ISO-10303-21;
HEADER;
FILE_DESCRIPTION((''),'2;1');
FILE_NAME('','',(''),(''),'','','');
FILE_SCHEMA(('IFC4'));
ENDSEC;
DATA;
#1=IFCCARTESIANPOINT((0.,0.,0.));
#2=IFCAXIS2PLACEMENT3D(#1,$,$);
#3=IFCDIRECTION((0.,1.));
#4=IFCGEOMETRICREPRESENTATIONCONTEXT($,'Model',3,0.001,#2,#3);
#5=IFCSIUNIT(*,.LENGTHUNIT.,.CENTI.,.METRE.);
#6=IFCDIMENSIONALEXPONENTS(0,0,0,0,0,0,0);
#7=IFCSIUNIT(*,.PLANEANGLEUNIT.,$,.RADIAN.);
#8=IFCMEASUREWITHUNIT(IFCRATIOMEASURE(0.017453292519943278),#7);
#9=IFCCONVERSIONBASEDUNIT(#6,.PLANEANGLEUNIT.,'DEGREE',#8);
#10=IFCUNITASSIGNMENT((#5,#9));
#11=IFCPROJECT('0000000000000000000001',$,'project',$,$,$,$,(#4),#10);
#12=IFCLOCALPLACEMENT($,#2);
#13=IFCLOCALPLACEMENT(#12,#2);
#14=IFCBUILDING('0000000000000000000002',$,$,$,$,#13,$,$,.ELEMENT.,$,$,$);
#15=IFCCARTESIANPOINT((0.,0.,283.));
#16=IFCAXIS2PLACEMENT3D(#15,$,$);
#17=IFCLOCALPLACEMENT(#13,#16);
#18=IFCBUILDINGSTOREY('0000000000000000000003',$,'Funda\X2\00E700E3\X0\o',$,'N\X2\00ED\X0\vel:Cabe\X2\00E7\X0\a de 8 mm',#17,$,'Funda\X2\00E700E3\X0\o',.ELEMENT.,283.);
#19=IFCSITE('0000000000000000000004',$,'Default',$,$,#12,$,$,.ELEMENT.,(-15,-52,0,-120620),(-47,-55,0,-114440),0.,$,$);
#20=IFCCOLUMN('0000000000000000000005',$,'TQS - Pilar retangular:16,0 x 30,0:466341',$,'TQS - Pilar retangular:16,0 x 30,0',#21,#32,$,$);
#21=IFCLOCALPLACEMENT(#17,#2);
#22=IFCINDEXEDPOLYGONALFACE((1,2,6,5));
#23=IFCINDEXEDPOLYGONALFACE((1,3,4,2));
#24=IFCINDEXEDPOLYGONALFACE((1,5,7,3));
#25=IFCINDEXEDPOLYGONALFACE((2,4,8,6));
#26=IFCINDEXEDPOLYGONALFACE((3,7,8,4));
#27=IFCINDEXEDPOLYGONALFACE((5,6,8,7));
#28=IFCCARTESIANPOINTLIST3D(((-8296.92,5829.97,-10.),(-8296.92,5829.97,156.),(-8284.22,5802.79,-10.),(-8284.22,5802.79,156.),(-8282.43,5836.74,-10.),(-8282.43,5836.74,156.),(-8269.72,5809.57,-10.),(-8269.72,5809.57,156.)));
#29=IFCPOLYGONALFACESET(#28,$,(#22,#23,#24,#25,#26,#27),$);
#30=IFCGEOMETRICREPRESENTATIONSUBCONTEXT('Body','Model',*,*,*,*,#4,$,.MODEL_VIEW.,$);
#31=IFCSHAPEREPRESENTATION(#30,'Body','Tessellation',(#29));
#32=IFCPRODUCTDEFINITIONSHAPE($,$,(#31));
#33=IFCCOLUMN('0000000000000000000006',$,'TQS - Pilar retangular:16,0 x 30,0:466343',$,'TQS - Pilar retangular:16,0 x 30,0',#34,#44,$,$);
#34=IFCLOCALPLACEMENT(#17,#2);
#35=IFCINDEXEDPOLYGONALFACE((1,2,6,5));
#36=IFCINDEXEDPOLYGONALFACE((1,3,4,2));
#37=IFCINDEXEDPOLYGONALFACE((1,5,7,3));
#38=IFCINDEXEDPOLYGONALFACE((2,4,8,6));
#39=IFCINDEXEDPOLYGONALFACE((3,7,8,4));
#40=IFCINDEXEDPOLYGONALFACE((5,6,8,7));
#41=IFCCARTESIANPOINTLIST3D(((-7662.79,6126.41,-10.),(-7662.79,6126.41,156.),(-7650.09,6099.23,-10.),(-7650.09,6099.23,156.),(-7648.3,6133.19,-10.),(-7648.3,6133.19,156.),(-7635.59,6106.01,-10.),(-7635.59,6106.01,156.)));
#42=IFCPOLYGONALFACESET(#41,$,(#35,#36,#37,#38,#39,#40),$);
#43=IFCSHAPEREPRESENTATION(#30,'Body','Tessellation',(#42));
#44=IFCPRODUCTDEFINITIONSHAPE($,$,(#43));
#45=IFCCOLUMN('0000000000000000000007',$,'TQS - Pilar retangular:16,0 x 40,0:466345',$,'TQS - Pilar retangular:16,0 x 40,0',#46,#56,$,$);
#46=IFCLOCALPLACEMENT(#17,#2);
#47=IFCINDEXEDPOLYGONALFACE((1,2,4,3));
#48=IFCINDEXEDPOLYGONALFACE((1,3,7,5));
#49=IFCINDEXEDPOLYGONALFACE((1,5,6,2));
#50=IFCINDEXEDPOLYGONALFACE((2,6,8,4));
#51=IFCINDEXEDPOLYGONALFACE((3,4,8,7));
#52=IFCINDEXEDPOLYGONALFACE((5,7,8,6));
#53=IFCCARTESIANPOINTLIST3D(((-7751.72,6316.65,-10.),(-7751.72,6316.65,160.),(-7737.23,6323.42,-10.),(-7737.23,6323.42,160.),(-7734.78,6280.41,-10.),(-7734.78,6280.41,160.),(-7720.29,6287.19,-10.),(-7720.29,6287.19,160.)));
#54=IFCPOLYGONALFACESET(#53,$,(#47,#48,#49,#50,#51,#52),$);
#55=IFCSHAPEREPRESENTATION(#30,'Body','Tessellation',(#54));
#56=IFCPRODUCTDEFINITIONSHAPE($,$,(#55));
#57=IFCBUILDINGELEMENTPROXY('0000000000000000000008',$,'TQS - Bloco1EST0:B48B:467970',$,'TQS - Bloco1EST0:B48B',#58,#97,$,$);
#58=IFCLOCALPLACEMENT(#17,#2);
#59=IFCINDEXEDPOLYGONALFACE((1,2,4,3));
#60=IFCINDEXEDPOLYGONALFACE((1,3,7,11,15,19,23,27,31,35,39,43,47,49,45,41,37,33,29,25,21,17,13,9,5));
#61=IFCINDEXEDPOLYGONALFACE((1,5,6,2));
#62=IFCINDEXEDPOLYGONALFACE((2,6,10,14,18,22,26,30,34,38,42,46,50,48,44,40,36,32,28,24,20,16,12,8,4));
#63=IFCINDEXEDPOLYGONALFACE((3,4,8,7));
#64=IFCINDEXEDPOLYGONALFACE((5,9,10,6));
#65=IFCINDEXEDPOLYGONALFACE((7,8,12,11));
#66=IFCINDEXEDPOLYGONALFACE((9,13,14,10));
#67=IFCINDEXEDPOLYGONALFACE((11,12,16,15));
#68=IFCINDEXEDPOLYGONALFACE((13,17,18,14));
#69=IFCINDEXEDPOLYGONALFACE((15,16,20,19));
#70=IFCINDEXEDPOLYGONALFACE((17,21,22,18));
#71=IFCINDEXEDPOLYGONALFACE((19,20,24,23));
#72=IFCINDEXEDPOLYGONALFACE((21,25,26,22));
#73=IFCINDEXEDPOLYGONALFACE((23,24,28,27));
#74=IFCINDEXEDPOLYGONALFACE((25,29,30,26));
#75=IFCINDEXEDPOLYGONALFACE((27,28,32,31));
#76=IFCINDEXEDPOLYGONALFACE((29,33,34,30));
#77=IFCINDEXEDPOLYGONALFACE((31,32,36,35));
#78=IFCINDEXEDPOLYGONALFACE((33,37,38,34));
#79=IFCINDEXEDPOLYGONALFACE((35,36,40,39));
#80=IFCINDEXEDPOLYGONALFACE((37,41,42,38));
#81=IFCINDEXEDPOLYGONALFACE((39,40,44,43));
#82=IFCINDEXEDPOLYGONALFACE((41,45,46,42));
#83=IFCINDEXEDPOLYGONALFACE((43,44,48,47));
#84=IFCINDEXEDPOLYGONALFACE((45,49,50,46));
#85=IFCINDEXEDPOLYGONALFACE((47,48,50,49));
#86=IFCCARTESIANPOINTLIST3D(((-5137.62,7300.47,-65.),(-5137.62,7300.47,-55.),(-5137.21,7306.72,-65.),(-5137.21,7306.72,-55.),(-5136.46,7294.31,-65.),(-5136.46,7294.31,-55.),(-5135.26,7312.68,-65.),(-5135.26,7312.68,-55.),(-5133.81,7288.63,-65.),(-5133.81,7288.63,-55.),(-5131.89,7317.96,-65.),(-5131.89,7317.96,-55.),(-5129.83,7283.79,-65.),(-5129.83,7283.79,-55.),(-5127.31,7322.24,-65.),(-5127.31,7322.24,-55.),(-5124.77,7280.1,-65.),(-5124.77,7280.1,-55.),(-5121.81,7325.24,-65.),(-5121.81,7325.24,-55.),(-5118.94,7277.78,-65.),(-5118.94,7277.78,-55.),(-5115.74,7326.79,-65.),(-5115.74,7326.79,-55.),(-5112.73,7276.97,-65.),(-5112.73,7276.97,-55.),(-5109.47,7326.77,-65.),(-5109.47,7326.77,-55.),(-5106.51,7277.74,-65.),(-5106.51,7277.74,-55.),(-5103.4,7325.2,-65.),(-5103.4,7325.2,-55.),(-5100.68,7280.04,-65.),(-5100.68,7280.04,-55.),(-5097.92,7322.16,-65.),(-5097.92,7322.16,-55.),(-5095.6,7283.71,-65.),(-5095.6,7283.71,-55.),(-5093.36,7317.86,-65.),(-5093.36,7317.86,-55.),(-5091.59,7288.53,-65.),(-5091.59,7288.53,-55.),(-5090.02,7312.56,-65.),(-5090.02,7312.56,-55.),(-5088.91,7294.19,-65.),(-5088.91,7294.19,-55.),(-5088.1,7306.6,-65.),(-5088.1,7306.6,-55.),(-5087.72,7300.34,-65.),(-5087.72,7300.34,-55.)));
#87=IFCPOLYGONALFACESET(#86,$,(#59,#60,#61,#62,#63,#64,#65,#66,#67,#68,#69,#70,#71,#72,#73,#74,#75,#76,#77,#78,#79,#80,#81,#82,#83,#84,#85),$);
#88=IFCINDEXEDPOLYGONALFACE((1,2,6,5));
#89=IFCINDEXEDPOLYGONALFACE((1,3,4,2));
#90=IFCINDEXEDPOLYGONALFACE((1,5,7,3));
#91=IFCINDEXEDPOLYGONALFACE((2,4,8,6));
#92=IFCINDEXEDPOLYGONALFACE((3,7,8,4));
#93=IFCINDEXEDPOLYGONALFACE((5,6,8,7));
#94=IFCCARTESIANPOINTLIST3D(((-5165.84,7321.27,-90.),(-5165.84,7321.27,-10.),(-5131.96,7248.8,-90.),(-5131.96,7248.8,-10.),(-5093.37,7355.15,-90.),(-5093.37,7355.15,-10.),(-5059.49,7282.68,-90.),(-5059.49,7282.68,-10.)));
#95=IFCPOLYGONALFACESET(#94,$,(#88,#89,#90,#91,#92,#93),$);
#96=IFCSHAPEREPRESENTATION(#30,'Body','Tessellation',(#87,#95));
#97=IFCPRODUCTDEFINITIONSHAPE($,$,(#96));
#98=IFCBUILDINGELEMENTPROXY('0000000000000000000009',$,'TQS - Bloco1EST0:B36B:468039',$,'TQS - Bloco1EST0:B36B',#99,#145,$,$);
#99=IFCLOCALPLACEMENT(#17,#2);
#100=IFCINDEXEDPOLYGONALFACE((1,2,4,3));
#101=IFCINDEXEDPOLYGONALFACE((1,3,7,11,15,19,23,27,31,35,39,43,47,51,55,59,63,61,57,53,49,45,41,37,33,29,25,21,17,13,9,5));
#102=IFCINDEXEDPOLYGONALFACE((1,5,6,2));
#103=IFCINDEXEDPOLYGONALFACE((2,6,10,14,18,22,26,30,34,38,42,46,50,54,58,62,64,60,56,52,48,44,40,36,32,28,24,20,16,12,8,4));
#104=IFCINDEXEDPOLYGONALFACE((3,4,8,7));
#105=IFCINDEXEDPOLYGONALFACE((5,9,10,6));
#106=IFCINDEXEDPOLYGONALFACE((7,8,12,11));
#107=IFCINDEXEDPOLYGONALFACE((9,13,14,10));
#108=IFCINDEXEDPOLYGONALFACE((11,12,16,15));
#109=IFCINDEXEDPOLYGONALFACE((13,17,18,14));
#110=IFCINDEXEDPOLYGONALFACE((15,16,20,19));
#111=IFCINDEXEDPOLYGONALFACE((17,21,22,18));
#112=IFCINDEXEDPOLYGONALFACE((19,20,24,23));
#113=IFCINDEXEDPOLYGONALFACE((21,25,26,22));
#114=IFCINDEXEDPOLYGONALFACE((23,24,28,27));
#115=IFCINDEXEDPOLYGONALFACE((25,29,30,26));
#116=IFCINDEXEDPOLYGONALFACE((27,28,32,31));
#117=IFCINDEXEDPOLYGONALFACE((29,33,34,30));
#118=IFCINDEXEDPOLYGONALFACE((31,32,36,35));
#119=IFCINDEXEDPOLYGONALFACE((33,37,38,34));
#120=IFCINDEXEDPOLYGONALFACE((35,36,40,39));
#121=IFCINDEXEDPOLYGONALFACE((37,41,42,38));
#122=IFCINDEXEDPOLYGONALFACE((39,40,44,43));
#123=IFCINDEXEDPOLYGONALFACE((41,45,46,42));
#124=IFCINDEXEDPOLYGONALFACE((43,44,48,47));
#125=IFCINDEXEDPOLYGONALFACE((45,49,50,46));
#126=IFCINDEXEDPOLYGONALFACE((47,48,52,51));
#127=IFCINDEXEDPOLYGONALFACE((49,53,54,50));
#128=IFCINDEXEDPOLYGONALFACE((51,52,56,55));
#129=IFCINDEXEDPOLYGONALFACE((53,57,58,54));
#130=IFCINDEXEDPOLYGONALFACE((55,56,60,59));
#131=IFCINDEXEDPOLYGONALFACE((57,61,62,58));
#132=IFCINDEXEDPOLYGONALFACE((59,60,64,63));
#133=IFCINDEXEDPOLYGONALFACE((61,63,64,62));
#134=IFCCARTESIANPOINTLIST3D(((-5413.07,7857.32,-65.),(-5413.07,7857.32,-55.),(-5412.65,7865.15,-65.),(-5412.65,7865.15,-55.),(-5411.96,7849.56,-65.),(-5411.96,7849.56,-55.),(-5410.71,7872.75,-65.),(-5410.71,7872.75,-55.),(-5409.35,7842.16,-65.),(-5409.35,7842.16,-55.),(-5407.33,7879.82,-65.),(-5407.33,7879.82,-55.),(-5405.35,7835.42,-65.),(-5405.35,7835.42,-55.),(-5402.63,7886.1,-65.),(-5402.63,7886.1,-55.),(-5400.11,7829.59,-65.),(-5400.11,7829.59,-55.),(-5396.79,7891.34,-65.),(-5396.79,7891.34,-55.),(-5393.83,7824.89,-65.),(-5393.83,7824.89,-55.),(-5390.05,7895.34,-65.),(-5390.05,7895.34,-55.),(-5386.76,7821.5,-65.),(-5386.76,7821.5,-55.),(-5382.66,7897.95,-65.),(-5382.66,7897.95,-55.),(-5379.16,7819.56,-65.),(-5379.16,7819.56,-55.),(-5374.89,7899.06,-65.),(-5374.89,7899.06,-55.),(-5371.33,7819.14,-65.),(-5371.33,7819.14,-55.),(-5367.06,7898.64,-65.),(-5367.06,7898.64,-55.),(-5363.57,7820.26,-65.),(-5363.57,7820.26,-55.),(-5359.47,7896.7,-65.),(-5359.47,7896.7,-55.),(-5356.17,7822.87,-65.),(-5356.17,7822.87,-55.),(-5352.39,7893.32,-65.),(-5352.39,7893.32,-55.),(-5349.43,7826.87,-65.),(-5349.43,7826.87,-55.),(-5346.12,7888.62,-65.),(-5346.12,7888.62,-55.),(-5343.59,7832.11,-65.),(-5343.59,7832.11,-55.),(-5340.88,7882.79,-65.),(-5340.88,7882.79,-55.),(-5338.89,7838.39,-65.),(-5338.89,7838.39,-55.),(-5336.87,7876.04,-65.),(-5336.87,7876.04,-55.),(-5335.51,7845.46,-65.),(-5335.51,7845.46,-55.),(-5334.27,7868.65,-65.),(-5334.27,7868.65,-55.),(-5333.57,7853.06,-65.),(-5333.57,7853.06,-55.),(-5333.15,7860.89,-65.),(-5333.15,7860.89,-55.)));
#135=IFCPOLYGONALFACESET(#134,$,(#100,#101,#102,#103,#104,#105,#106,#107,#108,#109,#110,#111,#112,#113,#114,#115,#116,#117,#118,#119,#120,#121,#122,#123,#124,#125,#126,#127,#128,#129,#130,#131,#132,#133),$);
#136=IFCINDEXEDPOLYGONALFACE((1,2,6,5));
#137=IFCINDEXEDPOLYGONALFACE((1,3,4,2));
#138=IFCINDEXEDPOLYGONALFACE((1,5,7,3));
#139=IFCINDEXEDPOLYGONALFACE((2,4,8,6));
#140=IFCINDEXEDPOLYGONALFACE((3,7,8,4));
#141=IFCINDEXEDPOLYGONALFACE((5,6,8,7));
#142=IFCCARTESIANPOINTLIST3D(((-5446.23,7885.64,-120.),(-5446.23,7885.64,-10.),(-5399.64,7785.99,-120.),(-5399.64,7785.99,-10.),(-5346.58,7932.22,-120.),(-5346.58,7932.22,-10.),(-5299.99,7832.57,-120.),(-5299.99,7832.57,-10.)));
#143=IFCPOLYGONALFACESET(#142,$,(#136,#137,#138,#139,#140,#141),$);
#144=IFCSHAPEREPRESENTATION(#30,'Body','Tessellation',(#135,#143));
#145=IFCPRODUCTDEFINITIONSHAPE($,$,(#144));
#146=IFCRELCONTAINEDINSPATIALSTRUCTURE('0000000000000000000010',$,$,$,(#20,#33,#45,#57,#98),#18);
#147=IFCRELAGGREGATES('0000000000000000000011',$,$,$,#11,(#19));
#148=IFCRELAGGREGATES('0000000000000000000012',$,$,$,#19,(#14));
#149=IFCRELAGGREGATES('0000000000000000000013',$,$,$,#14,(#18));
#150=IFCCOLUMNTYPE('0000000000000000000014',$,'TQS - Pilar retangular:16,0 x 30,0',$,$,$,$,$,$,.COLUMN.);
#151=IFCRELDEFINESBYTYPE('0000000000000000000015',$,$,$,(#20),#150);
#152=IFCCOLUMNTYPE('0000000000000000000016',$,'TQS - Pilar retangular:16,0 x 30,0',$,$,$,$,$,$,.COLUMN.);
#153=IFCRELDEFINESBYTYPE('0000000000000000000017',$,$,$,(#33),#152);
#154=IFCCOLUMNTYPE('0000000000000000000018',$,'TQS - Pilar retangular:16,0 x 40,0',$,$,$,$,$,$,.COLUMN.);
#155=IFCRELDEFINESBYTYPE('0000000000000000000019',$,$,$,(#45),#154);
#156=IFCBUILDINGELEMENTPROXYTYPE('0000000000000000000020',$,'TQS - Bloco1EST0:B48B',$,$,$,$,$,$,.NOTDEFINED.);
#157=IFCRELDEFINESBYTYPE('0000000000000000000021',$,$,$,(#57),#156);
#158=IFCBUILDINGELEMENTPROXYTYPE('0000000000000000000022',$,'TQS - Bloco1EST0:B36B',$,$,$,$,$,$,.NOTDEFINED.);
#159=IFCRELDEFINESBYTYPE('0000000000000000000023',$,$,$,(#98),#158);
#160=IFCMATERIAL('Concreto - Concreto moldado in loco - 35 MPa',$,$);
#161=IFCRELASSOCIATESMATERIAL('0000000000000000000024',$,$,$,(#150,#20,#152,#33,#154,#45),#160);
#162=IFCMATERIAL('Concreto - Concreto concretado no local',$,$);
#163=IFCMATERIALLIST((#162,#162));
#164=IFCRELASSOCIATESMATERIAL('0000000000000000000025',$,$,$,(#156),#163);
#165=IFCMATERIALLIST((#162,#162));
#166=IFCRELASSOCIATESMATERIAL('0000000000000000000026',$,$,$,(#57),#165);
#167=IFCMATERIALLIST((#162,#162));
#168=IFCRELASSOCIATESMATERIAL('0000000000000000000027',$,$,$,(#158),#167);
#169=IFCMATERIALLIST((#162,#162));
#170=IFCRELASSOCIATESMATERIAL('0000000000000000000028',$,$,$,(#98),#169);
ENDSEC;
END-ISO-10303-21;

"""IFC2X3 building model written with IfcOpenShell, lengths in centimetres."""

from ifc_helpers import new_model, entity, si_unit, converted_unit, direction, frame, frame_2d, origin, origin_2d_with_axis, place, context, subcontext, project, spatial, rectangle, circle, extrude, source, transform, mapped, material, material_list, type_object, type_shapes, element, save


model = new_model("IFC2X3")

# Units and contexts
model_context = context("Model", 3, precision=0.001, world=origin(), true_north=direction((0.0, 1.0)))
body_context = subcontext(model_context, "Body", "Model", "MODEL_VIEW")
ifc_project = project(units=[si_unit("LENGTHUNIT", "METRE", prefix="CENTI"), converted_unit("PLANEANGLEUNIT", "DEGREE", entity("IfcRatioMeasure", 0.017453292519943278), si_unit("PLANEANGLEUNIT", "RADIAN"), dimensions=[0, 0, 0, 0, 0, 0, 0])], contexts=[model_context])

# Site, building, storey
site_placement = place(None, origin())
site = spatial("IfcSite", under=ifc_project, at=site_placement, Name="Default", CompositionType="ELEMENT", RefLatitude=(-15, -52, 0, -120620), RefLongitude=(-47, -55, 0, -114440), RefElevation=0.0)
building_placement = place(site_placement, origin())
building = spatial("IfcBuilding", under=site, at=building_placement, CompositionType="ELEMENT")
storey_placement = place(building_placement, frame((0.0, 0.0, 283.0)))
storey = spatial("IfcBuildingStorey", under=building, at=storey_placement, Name="Fundação", ObjectType="Nível:Cabeça de 8 mm", LongName="Fundação", CompositionType="ELEMENT", Elevation=283.0)

# Columns
ifc_material_1 = material(Name="Concreto - Concreto moldado in loco - 35 MPa")
column_type_1 = type_object("IfcColumnType", Name="TQS - Pilar retangular:16,0 x 30,0", PredefinedType="COLUMN", material=ifc_material_1)
shared_shape_1 = source(origin(), body_context, "Body", "SweptSolid", [
    extrude(rectangle(XDim=30.0, YDim=16.0, at=frame_2d((0.0, 0.0), x_axis=(1.0, 0.0))), frame((-8283.32, 5819.77, 273.0), z_axis=(0.0, 0.0, 1.0), x_axis=(-0.423488, 0.905902, 0.0)), (0.0, 0.0, 1.0), 166.0),
])
type_shapes(column_type_1, [shared_shape_1])
column_1_placement = place(storey_placement, frame((0.0, 0.0, -283.0)))
element("IfcColumn", 1, at=column_1_placement, inside=storey, type_object=column_type_1, material=ifc_material_1, Name="TQS - Pilar retangular:16,0 x 30,0:466341", ObjectType="TQS - Pilar retangular:16,0 x 30,0", context=body_context, shape_type="MappedRepresentation", body=[
    mapped(shared_shape_1, transform((0.0, 0.0, 0.0), scale=1.0)),
])
column_type_2 = type_object("IfcColumnType", Name="TQS - Pilar retangular:16,0 x 30,0", PredefinedType="COLUMN", material=ifc_material_1)
shared_shape_2 = source(origin(), body_context, "Body", "SweptSolid", [
    extrude(rectangle(XDim=30.0, YDim=16.0, at=origin_2d_with_axis()), frame((-7649.19, 6116.21, 273.0), z_axis=(0.0, 0.0, 1.0), x_axis=(-0.423488, 0.905902, 0.0)), (0.0, 0.0, 1.0), 166.0),
])
type_shapes(column_type_2, [shared_shape_2])
column_2_placement = place(storey_placement, frame((0.0, 0.0, -283.0)))
element("IfcColumn", 2, at=column_2_placement, inside=storey, type_object=column_type_2, material=ifc_material_1, Name="TQS - Pilar retangular:16,0 x 30,0:466343", ObjectType="TQS - Pilar retangular:16,0 x 30,0", context=body_context, shape_type="MappedRepresentation", body=[
    mapped(shared_shape_2, transform((0.0, 0.0, 0.0), scale=1.0)),
])
column_type_3 = type_object("IfcColumnType", Name="TQS - Pilar retangular:16,0 x 40,0", PredefinedType="COLUMN", material=ifc_material_1)
shared_shape_3 = source(origin(), body_context, "Body", "SweptSolid", [
    extrude(rectangle(XDim=40.0, YDim=16.0, at=origin_2d_with_axis()), frame((-7736.01, 6301.92, 273.0), z_axis=(0.0, 0.0, 1.0), x_axis=(-0.423488, 0.905902, 0.0)), (0.0, 0.0, 1.0), 170.0),
])
type_shapes(column_type_3, [shared_shape_3])
column_3_placement = place(storey_placement, frame((0.0, 0.0, -283.0)))
element("IfcColumn", 3, at=column_3_placement, inside=storey, type_object=column_type_3, material=ifc_material_1, Name="TQS - Pilar retangular:16,0 x 40,0:466345", ObjectType="TQS - Pilar retangular:16,0 x 40,0", context=body_context, shape_type="MappedRepresentation", body=[
    mapped(shared_shape_3, transform((0.0, 0.0, 0.0), scale=1.0)),
])

# Building element proxies
ifc_material_2 = material(Name="Concreto - Concreto concretado no local")
ifc_material_list_1 = material_list([ifc_material_2, ifc_material_2])
ifc_material_list_2 = material_list([ifc_material_2, ifc_material_2])
building_element_proxy_type_1 = type_object("IfcBuildingElementProxyType", Name="TQS - Bloco1EST0:B48B", PredefinedType="NOTDEFINED", material=ifc_material_list_2)
shared_shape_4 = source(origin(), body_context, "Body", "SweptSolid", [
    extrude(circle(Radius=25.0, at=frame_2d((0.0, 0.0), x_axis=(1.0, 0.0))), frame((0.0, 0.0, -55.0)), (0.0, 0.0, 1.0), 10.0),
    extrude(rectangle(XDim=80.0, YDim=80.0, at=origin_2d_with_axis()), frame((0.0, 0.0, -80.0), z_axis=(0.0, 0.0, 1.0), x_axis=(-1.0, 0.0, 0.0)), (0.0, 0.0, 1.0), 80.0),
])
type_shapes(building_element_proxy_type_1, [shared_shape_4])
proxy_1_placement = place(storey_placement, frame((-5112.67, 7301.97, -10.0), z_axis=(0.0, 0.0, 1.0), x_axis=(0.905902, 0.423488, 0.0)))
element("IfcBuildingElementProxy", 4, at=proxy_1_placement, inside=storey, type_object=building_element_proxy_type_1, material=ifc_material_list_1, Name="TQS - Bloco1EST0:B48B:467970", ObjectType="TQS - Bloco1EST0:B48B", context=body_context, shape_type="MappedRepresentation", body=[
    mapped(shared_shape_4, transform((0.0, 0.0, 0.0), scale=1.0)),
])
ifc_material_list_3 = material_list([ifc_material_2, ifc_material_2])
ifc_material_list_4 = material_list([ifc_material_2, ifc_material_2])
building_element_proxy_type_2 = type_object("IfcBuildingElementProxyType", Name="TQS - Bloco1EST0:B36B", PredefinedType="NOTDEFINED", material=ifc_material_list_4)
shared_shape_5 = source(origin(), body_context, "Body", "SweptSolid", [
    extrude(circle(Radius=40.0, at=frame_2d((0.0, 0.0), x_axis=(1.0, 0.0))), frame((0.0, 0.0, -55.0)), (0.0, 0.0, 1.0), 10.0),
    extrude(rectangle(XDim=110.0, YDim=110.0, at=origin_2d_with_axis()), frame((0.0, 0.0, -110.0), z_axis=(0.0, 0.0, 1.0), x_axis=(-1.0, 0.0, 0.0)), (0.0, 0.0, 1.0), 110.0),
])
type_shapes(building_element_proxy_type_2, [shared_shape_5])
proxy_2_placement = place(storey_placement, frame((-5373.11, 7859.1, -10.0), z_axis=(0.0, 0.0, 1.0), x_axis=(0.905902, 0.423488, 0.0)))
element("IfcBuildingElementProxy", 5, at=proxy_2_placement, inside=storey, type_object=building_element_proxy_type_2, material=ifc_material_list_3, Name="TQS - Bloco1EST0:B36B:468039", ObjectType="TQS - Bloco1EST0:B36B", context=body_context, shape_type="MappedRepresentation", body=[
    mapped(shared_shape_5, transform((0.0, 0.0, 0.0), scale=1.0)),
])

save(model, "model.ifc")
